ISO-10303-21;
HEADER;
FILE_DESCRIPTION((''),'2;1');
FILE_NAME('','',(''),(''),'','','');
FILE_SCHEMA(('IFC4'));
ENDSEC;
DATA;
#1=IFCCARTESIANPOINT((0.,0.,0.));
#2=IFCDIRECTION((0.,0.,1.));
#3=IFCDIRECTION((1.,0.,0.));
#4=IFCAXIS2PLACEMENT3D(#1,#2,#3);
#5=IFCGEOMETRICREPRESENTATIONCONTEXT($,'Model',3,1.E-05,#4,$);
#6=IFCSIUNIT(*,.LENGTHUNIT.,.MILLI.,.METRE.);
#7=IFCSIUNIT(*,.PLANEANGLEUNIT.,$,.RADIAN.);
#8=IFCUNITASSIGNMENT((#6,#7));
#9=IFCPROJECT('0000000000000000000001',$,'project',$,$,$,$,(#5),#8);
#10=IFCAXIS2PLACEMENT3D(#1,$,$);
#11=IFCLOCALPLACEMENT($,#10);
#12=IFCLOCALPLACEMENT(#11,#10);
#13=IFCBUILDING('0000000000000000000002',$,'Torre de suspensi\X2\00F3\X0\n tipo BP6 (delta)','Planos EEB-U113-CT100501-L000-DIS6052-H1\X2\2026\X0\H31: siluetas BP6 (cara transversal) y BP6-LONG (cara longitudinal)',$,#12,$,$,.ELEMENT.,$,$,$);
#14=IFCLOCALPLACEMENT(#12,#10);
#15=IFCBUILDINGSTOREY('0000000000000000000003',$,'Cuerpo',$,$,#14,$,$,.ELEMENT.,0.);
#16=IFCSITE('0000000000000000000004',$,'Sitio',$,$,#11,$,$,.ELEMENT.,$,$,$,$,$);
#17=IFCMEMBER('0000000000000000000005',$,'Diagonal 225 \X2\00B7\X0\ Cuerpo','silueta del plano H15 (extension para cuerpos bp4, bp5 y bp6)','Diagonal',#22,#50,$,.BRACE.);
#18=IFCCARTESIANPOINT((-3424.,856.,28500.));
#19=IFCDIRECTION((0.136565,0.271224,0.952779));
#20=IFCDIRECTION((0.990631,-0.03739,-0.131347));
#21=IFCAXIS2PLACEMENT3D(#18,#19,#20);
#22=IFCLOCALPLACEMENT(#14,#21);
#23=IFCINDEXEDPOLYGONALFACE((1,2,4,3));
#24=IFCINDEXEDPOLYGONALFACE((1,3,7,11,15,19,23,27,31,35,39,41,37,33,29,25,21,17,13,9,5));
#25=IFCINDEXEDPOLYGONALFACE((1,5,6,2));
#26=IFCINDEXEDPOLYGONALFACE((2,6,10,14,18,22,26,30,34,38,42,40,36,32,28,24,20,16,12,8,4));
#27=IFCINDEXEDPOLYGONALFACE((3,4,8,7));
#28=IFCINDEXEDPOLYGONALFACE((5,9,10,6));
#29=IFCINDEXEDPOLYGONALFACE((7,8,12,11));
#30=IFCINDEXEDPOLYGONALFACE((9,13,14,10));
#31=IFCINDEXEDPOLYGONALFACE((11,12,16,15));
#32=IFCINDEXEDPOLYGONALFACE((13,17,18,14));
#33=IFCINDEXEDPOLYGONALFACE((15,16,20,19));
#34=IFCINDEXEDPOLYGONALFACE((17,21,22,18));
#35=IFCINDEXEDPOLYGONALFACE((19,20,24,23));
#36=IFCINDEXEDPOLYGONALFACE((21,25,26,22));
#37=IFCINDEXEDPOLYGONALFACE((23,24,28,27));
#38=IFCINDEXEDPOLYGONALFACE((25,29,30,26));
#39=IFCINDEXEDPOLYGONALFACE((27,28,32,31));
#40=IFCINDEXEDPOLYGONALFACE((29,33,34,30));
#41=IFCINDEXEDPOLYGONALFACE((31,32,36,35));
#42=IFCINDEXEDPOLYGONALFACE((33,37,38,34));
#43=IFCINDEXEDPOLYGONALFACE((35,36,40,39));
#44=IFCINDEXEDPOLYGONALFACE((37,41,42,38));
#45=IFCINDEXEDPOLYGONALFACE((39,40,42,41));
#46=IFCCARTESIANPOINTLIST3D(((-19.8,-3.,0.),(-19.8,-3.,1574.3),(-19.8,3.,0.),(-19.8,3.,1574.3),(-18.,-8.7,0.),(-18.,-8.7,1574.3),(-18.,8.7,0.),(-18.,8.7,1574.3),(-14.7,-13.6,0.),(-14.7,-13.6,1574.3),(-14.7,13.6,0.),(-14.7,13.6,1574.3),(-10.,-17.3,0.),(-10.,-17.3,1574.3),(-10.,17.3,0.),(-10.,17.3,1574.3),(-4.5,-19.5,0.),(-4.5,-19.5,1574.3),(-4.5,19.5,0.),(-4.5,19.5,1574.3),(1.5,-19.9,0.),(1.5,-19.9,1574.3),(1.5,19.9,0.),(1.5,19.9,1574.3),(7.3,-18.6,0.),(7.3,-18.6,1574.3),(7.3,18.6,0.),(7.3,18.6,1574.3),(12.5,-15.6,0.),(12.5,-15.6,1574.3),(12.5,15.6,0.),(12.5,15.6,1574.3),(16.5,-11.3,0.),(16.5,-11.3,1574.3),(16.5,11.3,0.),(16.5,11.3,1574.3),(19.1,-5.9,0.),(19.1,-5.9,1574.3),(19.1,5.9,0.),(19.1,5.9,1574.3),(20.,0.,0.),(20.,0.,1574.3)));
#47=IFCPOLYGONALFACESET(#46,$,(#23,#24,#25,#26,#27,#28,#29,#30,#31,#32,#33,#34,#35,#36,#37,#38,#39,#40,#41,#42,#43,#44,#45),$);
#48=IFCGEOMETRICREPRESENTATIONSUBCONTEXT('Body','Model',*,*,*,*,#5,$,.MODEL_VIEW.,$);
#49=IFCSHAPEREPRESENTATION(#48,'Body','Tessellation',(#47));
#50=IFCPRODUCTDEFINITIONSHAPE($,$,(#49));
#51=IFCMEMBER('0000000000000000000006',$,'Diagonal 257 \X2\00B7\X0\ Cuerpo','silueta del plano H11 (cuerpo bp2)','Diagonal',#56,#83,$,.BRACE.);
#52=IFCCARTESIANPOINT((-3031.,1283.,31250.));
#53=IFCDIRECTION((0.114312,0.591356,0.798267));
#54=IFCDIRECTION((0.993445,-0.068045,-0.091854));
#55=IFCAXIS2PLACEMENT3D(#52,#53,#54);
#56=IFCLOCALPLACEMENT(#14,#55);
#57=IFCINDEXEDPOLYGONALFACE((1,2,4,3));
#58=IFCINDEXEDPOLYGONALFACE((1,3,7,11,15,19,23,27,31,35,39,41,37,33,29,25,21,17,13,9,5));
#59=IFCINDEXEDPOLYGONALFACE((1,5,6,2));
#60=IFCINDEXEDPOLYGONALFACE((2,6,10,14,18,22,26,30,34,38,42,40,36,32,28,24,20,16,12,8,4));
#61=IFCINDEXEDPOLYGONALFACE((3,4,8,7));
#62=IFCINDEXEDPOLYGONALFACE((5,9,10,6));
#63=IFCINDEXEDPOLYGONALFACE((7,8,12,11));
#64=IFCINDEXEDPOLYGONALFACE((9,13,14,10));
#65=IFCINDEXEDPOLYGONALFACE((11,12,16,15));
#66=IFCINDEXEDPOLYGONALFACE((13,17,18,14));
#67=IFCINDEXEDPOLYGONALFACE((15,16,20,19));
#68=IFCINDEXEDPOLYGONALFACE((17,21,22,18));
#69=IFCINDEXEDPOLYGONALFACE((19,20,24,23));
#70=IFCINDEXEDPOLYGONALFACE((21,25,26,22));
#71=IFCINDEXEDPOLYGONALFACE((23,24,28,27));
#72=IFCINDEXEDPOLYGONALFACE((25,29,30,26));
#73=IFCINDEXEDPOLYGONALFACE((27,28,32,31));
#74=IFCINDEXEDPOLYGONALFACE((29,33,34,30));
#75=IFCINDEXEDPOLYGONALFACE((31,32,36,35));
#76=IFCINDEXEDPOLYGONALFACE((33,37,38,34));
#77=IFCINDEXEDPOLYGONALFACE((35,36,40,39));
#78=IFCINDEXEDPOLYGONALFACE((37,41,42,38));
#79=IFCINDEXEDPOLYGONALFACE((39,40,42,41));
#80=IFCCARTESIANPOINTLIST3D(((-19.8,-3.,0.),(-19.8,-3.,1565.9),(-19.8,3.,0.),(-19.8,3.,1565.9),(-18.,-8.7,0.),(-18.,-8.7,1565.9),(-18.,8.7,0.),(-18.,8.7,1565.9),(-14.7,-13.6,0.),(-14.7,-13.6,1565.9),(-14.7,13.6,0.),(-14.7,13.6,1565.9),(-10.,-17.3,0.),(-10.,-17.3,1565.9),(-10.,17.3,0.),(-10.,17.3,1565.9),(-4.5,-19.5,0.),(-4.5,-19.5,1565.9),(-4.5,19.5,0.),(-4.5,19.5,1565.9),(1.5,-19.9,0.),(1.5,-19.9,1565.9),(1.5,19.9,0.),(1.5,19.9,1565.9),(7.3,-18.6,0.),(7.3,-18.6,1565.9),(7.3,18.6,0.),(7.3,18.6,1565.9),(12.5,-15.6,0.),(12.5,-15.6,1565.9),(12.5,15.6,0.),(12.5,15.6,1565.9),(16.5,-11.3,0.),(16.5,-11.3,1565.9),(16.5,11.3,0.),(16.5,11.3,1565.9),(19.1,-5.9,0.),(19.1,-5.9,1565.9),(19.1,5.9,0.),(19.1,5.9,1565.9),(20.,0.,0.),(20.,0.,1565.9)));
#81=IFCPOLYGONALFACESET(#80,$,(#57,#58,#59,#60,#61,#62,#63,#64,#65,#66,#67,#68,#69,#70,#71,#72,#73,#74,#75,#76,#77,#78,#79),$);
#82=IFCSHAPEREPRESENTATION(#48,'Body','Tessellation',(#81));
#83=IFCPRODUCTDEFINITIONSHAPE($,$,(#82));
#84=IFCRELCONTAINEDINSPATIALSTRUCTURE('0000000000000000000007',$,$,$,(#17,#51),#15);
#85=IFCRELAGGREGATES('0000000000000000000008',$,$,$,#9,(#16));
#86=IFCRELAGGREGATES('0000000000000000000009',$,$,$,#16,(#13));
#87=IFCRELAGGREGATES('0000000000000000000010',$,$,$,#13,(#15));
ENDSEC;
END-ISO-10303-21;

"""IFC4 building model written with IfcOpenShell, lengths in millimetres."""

from ifc_helpers import new_model, si_unit, frame, origin, origin_with_axes, place, context, subcontext, project, spatial, circle, extrude, element, save


model = new_model("IFC4")

# Units and contexts
model_context = context("Model", 3, precision=1e-05, world=origin_with_axes())
body_context = subcontext(model_context, "Body", "Model", "MODEL_VIEW")
ifc_project = project(units=[si_unit("LENGTHUNIT", "METRE", prefix="MILLI"), si_unit("PLANEANGLEUNIT", "RADIAN")], contexts=[model_context])

# Site, building, storey
site_placement = place(None, origin())
site = spatial("IfcSite", under=ifc_project, at=site_placement, Name="Sitio", CompositionType="ELEMENT")
building_placement = place(site_placement, origin())
building = spatial("IfcBuilding", under=site, at=building_placement, Name="Torre de suspensión tipo BP6 (delta)", Description="Planos EEB-U113-CT100501-L000-DIS6052-H1…H31: siluetas BP6 (cara transversal) y BP6-LONG (cara longitudinal)", CompositionType="ELEMENT")
storey_placement = place(building_placement, origin())
storey = spatial("IfcBuildingStorey", under=building, at=storey_placement, Name="Cuerpo", CompositionType="ELEMENT", Elevation=0.0)

# Members
member_1_placement = place(storey_placement, frame((-3424.0, 856.0, 28500.0), z_axis=(0.136565, 0.271224, 0.952779), x_axis=(0.990631, -0.03739, -0.131347)))
element("IfcMember", 1, at=member_1_placement, inside=storey, Name="Diagonal 225 · Cuerpo", Description="silueta del plano H15 (extension para cuerpos bp4, bp5 y bp6)", ObjectType="Diagonal", PredefinedType="BRACE", context=body_context, shape_type="SweptSolid", body=[
    extrude(circle(Radius=20.0), None, (0.0, 0.0, 1.0), 1574.3),
])
member_2_placement = place(storey_placement, frame((-3031.0, 1283.0, 31250.0), z_axis=(0.114312, 0.591356, 0.798267), x_axis=(0.993445, -0.068045, -0.091854)))
element("IfcMember", 2, at=member_2_placement, inside=storey, Name="Diagonal 257 · Cuerpo", Description="silueta del plano H11 (cuerpo bp2)", ObjectType="Diagonal", PredefinedType="BRACE", context=body_context, shape_type="SweptSolid", body=[
    extrude(circle(Radius=20.0), None, (0.0, 0.0, 1.0), 1565.9),
])

save(model, "model.ifc")
